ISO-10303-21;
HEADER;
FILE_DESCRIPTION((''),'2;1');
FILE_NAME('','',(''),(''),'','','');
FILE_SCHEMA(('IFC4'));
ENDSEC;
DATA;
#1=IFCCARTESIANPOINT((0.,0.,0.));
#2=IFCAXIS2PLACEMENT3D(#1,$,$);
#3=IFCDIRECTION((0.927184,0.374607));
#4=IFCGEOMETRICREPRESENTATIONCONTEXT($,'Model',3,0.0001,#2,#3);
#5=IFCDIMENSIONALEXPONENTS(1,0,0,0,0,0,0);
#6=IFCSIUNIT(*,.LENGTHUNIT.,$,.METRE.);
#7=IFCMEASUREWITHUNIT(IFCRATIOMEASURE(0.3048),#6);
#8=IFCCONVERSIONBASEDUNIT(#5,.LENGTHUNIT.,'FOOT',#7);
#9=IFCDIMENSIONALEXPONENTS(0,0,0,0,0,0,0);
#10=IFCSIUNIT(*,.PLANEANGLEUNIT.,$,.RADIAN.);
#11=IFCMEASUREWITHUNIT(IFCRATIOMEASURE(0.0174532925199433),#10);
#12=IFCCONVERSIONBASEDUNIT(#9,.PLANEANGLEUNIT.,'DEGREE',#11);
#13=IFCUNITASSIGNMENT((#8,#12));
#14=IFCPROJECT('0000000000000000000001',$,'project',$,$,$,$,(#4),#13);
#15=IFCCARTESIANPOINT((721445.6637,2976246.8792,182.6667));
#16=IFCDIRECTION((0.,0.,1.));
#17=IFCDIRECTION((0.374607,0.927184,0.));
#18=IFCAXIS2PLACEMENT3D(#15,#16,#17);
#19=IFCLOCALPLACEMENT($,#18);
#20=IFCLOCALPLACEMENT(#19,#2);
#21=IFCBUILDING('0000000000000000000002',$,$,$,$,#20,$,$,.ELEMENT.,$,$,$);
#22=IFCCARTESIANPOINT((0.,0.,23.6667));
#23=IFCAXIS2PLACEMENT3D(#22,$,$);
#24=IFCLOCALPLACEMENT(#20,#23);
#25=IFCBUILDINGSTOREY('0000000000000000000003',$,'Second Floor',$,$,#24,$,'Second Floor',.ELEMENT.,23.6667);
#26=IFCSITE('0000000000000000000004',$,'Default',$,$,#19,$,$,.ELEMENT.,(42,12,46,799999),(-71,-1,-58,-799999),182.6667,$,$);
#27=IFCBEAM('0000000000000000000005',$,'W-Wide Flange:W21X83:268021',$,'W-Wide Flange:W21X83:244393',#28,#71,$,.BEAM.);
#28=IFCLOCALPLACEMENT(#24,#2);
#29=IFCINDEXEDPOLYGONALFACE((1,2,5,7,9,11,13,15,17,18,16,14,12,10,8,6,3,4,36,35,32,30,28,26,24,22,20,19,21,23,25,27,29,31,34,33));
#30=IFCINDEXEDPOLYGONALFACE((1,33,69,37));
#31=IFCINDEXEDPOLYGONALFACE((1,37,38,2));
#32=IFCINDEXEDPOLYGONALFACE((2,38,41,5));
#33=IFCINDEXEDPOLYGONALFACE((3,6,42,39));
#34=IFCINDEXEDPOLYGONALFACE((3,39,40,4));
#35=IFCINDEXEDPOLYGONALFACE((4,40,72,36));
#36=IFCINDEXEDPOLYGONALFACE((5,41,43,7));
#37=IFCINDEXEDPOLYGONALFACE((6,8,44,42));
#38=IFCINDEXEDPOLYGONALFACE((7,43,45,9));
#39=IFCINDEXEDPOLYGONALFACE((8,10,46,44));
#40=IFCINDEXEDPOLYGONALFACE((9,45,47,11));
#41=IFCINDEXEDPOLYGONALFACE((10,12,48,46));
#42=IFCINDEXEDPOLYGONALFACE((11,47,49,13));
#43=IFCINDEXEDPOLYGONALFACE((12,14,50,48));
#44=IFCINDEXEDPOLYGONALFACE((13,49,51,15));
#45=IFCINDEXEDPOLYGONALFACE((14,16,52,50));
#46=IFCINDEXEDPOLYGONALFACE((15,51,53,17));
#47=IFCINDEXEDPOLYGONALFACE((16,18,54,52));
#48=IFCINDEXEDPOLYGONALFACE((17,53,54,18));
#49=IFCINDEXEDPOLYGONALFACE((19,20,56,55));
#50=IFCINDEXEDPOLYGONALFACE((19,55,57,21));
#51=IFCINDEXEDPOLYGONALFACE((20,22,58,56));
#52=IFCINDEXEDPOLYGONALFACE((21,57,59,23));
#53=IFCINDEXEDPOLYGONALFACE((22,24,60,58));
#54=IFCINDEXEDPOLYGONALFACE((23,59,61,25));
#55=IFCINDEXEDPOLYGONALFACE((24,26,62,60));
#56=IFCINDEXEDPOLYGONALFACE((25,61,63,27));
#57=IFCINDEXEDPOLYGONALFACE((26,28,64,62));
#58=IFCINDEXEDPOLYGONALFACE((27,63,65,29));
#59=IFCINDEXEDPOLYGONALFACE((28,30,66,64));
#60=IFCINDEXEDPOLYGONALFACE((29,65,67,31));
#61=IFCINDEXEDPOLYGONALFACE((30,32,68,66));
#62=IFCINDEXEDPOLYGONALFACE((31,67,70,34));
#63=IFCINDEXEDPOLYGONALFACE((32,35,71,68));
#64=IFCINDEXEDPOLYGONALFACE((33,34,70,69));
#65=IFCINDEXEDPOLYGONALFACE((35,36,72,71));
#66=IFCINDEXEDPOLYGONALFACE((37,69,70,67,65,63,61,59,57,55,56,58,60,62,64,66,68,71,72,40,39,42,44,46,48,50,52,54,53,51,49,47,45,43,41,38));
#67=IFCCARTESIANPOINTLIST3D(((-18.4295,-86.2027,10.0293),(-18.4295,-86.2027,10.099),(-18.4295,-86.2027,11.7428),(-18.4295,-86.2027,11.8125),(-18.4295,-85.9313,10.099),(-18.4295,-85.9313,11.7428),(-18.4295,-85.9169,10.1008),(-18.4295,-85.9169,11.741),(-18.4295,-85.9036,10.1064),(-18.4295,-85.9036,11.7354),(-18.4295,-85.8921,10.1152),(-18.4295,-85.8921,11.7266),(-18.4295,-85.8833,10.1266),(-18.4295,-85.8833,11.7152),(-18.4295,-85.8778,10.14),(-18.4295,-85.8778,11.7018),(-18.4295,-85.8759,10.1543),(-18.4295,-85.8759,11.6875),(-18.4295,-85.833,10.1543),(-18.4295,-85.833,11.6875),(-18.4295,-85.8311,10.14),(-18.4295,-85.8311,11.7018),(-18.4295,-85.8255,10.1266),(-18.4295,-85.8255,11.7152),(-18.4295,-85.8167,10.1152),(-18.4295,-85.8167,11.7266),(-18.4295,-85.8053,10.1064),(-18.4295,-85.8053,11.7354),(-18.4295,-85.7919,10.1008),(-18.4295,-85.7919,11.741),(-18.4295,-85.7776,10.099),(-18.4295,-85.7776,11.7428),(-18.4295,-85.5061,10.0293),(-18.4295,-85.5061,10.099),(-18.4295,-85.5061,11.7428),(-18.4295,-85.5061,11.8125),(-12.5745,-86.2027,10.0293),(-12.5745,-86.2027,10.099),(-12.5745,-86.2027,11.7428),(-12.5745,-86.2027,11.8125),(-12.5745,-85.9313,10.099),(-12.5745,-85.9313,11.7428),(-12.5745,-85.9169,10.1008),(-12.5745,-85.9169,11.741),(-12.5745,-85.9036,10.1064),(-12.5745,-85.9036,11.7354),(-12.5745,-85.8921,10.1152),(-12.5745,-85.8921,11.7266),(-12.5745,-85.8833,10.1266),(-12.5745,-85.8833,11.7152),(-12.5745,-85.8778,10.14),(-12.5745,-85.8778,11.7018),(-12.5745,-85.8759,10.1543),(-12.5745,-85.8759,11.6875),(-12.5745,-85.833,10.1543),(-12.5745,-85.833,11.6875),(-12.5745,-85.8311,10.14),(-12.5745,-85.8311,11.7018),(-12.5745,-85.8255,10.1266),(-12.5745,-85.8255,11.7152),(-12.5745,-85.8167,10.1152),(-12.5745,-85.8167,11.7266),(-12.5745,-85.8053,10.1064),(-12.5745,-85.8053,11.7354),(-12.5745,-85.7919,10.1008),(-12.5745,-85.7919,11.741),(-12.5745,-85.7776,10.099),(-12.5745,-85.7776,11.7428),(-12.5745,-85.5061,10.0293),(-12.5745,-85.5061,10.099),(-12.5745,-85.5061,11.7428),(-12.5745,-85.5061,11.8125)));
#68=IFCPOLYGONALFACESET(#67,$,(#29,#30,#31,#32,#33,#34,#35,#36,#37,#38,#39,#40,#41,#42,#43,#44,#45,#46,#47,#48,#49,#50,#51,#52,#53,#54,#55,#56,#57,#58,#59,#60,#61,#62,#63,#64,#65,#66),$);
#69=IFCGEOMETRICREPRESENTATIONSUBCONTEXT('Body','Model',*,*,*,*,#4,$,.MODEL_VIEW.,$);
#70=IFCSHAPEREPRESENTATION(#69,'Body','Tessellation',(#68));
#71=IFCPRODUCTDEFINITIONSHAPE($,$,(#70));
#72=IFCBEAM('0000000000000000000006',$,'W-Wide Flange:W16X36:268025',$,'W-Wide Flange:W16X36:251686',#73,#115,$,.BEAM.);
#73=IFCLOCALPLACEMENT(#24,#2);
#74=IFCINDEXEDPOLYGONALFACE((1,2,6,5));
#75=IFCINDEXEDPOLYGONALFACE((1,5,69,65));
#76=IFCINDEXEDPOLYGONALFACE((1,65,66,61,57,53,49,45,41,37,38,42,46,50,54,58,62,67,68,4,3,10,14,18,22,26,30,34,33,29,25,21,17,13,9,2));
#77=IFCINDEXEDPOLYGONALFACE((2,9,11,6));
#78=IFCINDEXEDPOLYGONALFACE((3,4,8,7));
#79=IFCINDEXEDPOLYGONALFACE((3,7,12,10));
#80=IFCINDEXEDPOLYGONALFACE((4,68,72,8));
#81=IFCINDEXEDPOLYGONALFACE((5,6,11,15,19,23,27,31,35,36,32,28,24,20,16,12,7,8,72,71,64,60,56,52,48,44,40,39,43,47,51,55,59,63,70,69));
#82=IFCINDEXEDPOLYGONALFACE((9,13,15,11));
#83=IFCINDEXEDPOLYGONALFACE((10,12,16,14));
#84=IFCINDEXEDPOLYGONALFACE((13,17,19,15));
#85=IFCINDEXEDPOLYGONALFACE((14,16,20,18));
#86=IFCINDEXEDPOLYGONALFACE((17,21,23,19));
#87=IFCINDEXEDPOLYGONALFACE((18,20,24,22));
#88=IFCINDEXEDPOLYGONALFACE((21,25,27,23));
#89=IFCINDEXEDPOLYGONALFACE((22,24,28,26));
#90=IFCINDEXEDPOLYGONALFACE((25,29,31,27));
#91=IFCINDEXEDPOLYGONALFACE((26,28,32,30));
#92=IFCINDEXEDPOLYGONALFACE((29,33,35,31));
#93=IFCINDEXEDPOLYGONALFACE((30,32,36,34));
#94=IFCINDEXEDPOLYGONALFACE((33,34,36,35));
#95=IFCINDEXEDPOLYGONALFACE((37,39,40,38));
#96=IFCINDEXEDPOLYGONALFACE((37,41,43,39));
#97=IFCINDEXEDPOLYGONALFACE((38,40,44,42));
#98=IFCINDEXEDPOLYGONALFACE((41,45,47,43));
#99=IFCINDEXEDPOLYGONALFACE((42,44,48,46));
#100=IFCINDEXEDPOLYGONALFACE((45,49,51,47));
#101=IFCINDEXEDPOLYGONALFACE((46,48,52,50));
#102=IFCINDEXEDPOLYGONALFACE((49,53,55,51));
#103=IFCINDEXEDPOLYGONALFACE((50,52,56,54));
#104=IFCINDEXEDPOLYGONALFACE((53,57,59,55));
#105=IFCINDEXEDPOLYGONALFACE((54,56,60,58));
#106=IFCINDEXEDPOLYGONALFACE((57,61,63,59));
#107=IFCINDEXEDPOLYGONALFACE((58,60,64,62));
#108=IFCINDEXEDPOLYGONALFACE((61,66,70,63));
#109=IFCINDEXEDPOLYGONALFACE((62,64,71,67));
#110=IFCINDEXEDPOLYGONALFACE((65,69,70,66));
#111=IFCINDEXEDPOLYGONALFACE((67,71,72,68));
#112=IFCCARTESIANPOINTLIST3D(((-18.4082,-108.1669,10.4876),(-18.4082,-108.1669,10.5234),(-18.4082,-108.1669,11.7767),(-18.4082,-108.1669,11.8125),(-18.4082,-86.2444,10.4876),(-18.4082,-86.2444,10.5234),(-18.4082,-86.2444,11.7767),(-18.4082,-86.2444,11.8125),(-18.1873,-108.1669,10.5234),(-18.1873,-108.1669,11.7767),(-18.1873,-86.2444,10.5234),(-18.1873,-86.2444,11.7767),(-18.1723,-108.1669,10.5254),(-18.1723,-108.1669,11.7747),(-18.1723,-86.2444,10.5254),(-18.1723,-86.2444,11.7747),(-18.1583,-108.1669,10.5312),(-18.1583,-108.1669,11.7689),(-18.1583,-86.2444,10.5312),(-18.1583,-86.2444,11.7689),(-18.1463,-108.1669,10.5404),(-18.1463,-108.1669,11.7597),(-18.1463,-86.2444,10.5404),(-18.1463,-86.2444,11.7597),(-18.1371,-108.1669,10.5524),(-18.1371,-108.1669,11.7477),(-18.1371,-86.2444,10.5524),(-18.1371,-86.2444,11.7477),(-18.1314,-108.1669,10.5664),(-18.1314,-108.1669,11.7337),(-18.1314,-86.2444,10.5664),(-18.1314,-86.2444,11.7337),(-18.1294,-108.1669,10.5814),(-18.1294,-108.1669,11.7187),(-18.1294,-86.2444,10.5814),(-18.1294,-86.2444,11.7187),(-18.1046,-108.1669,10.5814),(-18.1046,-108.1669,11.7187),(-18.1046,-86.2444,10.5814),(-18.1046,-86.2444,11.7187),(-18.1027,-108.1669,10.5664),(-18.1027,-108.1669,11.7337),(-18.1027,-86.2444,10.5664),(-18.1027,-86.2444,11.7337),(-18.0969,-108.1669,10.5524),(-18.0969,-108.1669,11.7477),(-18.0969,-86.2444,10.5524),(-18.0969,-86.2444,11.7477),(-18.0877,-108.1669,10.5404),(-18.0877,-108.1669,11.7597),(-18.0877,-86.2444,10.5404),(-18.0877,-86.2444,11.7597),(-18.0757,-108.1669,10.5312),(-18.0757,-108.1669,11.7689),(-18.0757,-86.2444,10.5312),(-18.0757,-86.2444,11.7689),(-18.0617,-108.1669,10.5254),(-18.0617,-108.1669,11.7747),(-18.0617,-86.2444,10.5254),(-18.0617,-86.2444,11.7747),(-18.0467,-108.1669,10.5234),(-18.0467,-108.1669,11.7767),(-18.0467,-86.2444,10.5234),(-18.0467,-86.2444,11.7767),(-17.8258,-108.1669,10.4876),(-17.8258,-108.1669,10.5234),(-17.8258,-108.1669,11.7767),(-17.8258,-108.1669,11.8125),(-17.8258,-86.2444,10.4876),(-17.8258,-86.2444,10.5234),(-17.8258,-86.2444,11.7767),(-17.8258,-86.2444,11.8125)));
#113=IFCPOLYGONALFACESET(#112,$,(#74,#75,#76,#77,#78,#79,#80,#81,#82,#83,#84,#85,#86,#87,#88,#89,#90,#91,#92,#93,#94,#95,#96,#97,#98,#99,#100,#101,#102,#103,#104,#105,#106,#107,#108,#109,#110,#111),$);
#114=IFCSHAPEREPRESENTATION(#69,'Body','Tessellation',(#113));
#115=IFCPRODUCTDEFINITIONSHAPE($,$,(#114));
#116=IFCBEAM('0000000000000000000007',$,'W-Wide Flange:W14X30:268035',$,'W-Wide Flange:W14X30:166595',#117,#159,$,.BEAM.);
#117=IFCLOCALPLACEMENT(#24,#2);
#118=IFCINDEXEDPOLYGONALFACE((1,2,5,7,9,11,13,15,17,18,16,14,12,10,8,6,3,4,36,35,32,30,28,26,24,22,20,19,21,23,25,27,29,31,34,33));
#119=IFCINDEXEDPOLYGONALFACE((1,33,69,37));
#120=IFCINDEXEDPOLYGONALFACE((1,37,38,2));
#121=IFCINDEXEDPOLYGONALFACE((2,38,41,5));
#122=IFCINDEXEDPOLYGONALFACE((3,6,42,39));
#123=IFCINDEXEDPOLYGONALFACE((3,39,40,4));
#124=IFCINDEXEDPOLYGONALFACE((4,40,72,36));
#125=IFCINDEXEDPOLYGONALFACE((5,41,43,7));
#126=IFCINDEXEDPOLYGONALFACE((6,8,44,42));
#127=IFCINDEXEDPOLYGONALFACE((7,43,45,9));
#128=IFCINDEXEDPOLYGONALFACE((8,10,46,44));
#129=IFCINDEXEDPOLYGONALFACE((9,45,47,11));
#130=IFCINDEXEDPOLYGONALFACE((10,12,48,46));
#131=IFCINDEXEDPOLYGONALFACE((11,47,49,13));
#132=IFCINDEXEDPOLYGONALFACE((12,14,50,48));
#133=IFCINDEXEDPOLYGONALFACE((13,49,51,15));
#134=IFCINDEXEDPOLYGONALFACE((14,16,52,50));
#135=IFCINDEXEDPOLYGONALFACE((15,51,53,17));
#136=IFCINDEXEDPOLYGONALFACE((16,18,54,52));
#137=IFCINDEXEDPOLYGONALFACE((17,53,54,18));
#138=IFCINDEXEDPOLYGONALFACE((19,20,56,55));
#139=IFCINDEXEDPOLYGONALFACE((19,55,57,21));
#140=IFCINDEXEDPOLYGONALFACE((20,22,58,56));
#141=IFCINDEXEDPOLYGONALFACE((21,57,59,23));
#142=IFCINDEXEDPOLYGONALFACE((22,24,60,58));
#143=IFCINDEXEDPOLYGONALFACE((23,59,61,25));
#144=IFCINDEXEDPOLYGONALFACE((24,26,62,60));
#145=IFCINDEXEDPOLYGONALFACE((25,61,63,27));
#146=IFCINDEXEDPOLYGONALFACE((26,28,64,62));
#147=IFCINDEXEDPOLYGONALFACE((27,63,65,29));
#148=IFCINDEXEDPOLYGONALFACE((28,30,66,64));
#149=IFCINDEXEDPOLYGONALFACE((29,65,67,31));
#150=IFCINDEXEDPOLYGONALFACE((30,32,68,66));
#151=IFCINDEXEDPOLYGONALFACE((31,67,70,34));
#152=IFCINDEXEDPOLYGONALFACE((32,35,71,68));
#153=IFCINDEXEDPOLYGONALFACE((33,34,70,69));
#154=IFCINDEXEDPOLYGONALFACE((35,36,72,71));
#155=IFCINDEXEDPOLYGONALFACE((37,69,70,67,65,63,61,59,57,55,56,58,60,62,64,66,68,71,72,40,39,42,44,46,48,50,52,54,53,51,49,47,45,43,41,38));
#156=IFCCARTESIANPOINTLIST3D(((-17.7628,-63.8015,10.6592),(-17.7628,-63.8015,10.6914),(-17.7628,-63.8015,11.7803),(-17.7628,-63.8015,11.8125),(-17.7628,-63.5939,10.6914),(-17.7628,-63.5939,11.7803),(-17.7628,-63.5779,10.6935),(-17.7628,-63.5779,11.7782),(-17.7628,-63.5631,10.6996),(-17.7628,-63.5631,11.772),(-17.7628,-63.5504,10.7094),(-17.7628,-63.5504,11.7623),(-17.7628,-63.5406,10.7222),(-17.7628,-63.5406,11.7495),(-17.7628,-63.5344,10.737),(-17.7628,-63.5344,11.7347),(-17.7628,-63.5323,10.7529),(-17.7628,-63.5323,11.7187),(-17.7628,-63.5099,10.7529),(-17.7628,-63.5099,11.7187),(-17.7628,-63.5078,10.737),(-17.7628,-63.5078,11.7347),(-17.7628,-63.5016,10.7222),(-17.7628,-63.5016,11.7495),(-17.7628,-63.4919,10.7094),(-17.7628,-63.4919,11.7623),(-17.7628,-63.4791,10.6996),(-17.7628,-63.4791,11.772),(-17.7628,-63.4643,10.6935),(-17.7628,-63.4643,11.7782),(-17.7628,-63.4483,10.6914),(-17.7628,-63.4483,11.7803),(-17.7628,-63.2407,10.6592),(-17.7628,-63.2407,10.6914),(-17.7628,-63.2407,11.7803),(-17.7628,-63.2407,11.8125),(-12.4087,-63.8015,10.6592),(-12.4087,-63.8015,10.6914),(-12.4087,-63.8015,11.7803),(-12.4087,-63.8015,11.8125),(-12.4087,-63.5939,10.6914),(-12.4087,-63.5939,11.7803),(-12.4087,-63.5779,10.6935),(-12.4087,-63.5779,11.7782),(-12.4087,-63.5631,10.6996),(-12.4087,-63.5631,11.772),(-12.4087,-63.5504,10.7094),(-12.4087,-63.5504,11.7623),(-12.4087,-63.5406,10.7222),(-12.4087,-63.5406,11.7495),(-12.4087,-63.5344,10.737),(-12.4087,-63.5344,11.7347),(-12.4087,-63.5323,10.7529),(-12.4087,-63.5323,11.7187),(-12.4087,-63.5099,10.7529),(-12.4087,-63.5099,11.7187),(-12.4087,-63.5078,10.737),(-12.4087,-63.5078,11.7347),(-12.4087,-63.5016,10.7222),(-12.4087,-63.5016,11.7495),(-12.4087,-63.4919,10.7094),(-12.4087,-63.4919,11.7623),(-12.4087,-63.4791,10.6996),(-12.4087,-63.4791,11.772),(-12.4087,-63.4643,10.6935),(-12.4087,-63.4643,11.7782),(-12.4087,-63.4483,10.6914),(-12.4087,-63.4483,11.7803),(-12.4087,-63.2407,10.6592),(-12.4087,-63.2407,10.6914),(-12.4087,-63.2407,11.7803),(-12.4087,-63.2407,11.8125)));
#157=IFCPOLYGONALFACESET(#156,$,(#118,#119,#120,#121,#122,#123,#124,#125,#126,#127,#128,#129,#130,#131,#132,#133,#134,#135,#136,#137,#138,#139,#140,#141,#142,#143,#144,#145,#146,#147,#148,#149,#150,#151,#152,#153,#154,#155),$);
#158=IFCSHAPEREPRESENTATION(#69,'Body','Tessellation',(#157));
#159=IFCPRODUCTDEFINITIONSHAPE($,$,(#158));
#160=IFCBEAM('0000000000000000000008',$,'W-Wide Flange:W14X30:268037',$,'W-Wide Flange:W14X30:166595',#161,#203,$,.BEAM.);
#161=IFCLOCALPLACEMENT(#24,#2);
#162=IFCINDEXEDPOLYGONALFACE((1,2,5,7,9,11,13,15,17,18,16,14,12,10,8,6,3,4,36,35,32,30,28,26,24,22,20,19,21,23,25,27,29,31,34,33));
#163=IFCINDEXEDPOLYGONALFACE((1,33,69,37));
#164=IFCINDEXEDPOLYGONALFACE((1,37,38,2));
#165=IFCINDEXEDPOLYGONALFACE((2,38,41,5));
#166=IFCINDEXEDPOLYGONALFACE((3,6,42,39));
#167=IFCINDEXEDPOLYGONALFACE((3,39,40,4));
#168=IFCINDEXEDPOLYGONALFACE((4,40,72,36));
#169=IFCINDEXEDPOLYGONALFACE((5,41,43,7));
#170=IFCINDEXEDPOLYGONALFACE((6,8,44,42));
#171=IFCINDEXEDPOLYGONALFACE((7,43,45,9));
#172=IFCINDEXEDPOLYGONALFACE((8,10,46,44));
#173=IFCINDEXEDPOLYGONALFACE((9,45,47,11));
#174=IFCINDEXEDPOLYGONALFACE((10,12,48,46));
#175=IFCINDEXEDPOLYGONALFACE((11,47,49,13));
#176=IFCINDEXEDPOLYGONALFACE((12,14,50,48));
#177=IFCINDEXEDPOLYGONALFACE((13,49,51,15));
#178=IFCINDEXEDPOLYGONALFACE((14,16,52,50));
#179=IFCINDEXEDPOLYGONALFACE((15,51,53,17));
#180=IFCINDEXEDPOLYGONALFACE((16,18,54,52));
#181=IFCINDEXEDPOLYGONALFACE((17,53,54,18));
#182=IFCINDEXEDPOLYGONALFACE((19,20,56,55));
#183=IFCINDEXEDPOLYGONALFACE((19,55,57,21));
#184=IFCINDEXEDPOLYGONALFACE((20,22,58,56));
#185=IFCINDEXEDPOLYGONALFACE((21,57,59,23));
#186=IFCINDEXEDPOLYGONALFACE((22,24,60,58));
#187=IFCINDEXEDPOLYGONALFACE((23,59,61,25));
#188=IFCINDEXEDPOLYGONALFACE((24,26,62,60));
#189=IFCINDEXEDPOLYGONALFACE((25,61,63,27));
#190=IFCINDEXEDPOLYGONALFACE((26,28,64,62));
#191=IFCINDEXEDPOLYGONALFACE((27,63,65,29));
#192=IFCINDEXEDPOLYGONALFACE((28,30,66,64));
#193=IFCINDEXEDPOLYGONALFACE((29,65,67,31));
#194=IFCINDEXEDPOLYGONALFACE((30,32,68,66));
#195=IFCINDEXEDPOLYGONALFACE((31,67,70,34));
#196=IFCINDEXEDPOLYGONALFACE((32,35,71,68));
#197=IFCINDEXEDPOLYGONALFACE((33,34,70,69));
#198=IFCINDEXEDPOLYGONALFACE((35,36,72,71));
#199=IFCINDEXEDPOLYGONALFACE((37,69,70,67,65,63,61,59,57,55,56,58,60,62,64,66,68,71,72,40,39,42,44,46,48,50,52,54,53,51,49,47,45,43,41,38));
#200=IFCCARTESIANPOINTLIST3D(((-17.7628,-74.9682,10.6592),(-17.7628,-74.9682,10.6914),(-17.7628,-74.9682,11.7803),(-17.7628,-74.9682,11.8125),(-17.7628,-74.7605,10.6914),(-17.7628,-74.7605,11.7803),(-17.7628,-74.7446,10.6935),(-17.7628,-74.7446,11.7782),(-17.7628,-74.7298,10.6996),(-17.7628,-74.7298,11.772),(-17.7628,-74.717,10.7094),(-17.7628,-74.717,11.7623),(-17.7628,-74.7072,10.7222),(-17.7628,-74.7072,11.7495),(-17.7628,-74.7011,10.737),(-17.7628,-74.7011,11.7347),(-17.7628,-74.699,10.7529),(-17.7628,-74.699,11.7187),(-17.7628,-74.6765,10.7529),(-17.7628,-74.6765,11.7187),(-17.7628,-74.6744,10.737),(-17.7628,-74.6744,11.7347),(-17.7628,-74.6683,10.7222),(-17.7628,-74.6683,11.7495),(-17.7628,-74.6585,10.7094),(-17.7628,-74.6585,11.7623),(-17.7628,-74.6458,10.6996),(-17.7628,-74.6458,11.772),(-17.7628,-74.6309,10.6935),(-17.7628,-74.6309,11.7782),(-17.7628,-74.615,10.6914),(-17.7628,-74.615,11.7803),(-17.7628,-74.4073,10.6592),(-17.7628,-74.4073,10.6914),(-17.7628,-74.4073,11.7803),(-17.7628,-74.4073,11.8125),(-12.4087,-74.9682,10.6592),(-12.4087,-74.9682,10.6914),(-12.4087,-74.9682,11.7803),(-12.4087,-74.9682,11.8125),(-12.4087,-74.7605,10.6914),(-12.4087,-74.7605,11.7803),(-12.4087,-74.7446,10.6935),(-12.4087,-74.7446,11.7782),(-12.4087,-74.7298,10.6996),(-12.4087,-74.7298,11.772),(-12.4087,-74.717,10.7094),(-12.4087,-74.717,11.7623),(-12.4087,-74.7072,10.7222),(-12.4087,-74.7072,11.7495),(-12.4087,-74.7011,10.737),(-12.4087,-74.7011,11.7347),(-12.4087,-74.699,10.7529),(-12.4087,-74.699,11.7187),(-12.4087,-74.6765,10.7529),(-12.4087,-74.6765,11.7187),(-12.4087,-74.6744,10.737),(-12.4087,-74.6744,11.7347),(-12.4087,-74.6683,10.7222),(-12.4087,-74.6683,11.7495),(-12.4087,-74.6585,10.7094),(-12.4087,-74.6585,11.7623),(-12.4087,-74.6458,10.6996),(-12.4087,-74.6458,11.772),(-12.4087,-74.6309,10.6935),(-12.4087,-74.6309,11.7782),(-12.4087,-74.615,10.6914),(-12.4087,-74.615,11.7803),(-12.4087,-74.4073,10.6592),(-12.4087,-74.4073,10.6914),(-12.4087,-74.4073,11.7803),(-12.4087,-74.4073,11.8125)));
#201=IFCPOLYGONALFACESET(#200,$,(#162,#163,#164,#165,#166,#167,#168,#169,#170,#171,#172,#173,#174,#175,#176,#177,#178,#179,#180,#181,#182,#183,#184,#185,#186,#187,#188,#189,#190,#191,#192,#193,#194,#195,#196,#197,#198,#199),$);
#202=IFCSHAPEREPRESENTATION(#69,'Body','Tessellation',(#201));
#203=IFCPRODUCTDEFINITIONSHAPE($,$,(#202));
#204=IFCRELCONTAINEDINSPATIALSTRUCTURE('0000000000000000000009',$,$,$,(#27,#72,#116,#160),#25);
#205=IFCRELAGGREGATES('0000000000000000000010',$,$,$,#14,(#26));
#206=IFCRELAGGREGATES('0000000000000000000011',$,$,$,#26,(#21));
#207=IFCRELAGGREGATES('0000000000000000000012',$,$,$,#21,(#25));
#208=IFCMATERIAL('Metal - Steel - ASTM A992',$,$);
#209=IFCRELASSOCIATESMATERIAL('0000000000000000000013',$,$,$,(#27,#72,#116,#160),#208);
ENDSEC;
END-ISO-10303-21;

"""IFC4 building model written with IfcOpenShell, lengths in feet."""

from ifc_helpers import new_model, entity, si_unit, converted_unit, direction, frame, frame_2d, origin, place, context, subcontext, project, spatial, i_section, extrude, material, element, save


model = new_model("IFC4")

# Units and contexts
model_context = context("Model", 3, precision=0.0001, world=origin(), true_north=direction((0.927184, 0.374607)))
body_context = subcontext(model_context, "Body", "Model", "MODEL_VIEW")
ifc_project = project(units=[converted_unit("LENGTHUNIT", "FOOT", entity("IfcRatioMeasure", 0.3048), si_unit("LENGTHUNIT", "METRE"), dimensions=[1, 0, 0, 0, 0, 0, 0]), converted_unit("PLANEANGLEUNIT", "DEGREE", entity("IfcRatioMeasure", 0.0174532925199433), si_unit("PLANEANGLEUNIT", "RADIAN"), dimensions=[0, 0, 0, 0, 0, 0, 0])], contexts=[model_context])

# Site, building, storey
site_placement = place(None, frame((721445.6637, 2976246.8792, 182.6667), z_axis=(0.0, 0.0, 1.0), x_axis=(0.374607, 0.927184, 0.0)))
site = spatial("IfcSite", under=ifc_project, at=site_placement, Name="Default", CompositionType="ELEMENT", RefLatitude=(42, 12, 46, 799999), RefLongitude=(-71, -1, -58, -799999), RefElevation=182.6667)
building_placement = place(site_placement, origin())
building = spatial("IfcBuilding", under=site, at=building_placement, CompositionType="ELEMENT")
storey_placement = place(building_placement, frame((0.0, 0.0, 23.6667)))
storey = spatial("IfcBuildingStorey", under=building, at=storey_placement, Name="Second Floor", LongName="Second Floor", CompositionType="ELEMENT", Elevation=23.6667)

# Shared definitions
ifc_material_1 = material(Name="Metal - Steel - ASTM A992")

# Beams
beam_1_placement = place(storey_placement, frame((-12.117, -85.8544, 11.8125), z_axis=(0.0, 0.0, 1.0), x_axis=(-1.0, 0.0, 0.0)))
element("IfcBeam", 1, at=beam_1_placement, inside=storey, material=ifc_material_1, Name="W-Wide Flange:W21X83:268021", ObjectType="W-Wide Flange:W21X83:244393", PredefinedType="BEAM", context=body_context, shape_type="SweptSolid", body=[
    extrude(i_section(OverallWidth=0.6966, OverallDepth=1.7832, WebThickness=0.043, FlangeThickness=0.0697, FilletRadius=0.0553, at=frame_2d((0.0, 0.0), x_axis=(0.0, 1.0))), frame((0.4575, 0.0, -0.8916), z_axis=(1.0, 0.0, 0.0), x_axis=(0.0, 0.0, -1.0)), (0.0, 0.0, 1.0), 5.855),
])
beam_2_placement = place(storey_placement, frame((-18.117, -85.8544, 11.8125), z_axis=(0.0, 0.0, 1.0), x_axis=(0.0, -1.0, 0.0)))
element("IfcBeam", 2, at=beam_2_placement, inside=storey, material=ifc_material_1, Name="W-Wide Flange:W16X36:268025", ObjectType="W-Wide Flange:W16X36:251686", PredefinedType="BEAM", context=body_context, shape_type="SweptSolid", body=[
    extrude(i_section(OverallWidth=0.5824, OverallDepth=1.3249, WebThickness=0.0247, FlangeThickness=0.0358, FilletRadius=0.0579, at=frame_2d((0.0, 0.0), x_axis=(0.0, 1.0))), frame((0.39, 0.0, -0.6624), z_axis=(1.0, 0.0, 0.0), x_axis=(0.0, 0.0, -1.0)), (0.0, 0.0, 1.0), 21.9225),
])
beam_3_placement = place(storey_placement, frame((-18.117, -63.5211, 11.8125)))
element("IfcBeam", 3, at=beam_3_placement, inside=storey, material=ifc_material_1, Name="W-Wide Flange:W14X30:268035", ObjectType="W-Wide Flange:W14X30:166595", PredefinedType="BEAM", context=body_context, shape_type="SweptSolid", body=[
    extrude(i_section(OverallWidth=0.5609, OverallDepth=1.1533, WebThickness=0.0225, FlangeThickness=0.0322, FilletRadius=0.0615, at=frame_2d((0.0, 0.0), x_axis=(0.0, 1.0))), frame((0.3542, 0.0, -0.5767), z_axis=(1.0, 0.0, 0.0), x_axis=(0.0, 0.0, -1.0)), (0.0, 0.0, 1.0), 5.3542),
])
beam_4_placement = place(storey_placement, frame((-18.117, -74.6878, 11.8125)))
element("IfcBeam", 4, at=beam_4_placement, inside=storey, material=ifc_material_1, Name="W-Wide Flange:W14X30:268037", ObjectType="W-Wide Flange:W14X30:166595", PredefinedType="BEAM", context=body_context, shape_type="SweptSolid", body=[
    extrude(i_section(OverallWidth=0.5609, OverallDepth=1.1533, WebThickness=0.0225, FlangeThickness=0.0322, FilletRadius=0.0615, at=frame_2d((0.0, 0.0), x_axis=(0.0, 1.0))), frame((0.3542, 0.0, -0.5767), z_axis=(1.0, 0.0, 0.0), x_axis=(0.0, 0.0, -1.0)), (0.0, 0.0, 1.0), 5.3542),
])

save(model, "model.ifc")
